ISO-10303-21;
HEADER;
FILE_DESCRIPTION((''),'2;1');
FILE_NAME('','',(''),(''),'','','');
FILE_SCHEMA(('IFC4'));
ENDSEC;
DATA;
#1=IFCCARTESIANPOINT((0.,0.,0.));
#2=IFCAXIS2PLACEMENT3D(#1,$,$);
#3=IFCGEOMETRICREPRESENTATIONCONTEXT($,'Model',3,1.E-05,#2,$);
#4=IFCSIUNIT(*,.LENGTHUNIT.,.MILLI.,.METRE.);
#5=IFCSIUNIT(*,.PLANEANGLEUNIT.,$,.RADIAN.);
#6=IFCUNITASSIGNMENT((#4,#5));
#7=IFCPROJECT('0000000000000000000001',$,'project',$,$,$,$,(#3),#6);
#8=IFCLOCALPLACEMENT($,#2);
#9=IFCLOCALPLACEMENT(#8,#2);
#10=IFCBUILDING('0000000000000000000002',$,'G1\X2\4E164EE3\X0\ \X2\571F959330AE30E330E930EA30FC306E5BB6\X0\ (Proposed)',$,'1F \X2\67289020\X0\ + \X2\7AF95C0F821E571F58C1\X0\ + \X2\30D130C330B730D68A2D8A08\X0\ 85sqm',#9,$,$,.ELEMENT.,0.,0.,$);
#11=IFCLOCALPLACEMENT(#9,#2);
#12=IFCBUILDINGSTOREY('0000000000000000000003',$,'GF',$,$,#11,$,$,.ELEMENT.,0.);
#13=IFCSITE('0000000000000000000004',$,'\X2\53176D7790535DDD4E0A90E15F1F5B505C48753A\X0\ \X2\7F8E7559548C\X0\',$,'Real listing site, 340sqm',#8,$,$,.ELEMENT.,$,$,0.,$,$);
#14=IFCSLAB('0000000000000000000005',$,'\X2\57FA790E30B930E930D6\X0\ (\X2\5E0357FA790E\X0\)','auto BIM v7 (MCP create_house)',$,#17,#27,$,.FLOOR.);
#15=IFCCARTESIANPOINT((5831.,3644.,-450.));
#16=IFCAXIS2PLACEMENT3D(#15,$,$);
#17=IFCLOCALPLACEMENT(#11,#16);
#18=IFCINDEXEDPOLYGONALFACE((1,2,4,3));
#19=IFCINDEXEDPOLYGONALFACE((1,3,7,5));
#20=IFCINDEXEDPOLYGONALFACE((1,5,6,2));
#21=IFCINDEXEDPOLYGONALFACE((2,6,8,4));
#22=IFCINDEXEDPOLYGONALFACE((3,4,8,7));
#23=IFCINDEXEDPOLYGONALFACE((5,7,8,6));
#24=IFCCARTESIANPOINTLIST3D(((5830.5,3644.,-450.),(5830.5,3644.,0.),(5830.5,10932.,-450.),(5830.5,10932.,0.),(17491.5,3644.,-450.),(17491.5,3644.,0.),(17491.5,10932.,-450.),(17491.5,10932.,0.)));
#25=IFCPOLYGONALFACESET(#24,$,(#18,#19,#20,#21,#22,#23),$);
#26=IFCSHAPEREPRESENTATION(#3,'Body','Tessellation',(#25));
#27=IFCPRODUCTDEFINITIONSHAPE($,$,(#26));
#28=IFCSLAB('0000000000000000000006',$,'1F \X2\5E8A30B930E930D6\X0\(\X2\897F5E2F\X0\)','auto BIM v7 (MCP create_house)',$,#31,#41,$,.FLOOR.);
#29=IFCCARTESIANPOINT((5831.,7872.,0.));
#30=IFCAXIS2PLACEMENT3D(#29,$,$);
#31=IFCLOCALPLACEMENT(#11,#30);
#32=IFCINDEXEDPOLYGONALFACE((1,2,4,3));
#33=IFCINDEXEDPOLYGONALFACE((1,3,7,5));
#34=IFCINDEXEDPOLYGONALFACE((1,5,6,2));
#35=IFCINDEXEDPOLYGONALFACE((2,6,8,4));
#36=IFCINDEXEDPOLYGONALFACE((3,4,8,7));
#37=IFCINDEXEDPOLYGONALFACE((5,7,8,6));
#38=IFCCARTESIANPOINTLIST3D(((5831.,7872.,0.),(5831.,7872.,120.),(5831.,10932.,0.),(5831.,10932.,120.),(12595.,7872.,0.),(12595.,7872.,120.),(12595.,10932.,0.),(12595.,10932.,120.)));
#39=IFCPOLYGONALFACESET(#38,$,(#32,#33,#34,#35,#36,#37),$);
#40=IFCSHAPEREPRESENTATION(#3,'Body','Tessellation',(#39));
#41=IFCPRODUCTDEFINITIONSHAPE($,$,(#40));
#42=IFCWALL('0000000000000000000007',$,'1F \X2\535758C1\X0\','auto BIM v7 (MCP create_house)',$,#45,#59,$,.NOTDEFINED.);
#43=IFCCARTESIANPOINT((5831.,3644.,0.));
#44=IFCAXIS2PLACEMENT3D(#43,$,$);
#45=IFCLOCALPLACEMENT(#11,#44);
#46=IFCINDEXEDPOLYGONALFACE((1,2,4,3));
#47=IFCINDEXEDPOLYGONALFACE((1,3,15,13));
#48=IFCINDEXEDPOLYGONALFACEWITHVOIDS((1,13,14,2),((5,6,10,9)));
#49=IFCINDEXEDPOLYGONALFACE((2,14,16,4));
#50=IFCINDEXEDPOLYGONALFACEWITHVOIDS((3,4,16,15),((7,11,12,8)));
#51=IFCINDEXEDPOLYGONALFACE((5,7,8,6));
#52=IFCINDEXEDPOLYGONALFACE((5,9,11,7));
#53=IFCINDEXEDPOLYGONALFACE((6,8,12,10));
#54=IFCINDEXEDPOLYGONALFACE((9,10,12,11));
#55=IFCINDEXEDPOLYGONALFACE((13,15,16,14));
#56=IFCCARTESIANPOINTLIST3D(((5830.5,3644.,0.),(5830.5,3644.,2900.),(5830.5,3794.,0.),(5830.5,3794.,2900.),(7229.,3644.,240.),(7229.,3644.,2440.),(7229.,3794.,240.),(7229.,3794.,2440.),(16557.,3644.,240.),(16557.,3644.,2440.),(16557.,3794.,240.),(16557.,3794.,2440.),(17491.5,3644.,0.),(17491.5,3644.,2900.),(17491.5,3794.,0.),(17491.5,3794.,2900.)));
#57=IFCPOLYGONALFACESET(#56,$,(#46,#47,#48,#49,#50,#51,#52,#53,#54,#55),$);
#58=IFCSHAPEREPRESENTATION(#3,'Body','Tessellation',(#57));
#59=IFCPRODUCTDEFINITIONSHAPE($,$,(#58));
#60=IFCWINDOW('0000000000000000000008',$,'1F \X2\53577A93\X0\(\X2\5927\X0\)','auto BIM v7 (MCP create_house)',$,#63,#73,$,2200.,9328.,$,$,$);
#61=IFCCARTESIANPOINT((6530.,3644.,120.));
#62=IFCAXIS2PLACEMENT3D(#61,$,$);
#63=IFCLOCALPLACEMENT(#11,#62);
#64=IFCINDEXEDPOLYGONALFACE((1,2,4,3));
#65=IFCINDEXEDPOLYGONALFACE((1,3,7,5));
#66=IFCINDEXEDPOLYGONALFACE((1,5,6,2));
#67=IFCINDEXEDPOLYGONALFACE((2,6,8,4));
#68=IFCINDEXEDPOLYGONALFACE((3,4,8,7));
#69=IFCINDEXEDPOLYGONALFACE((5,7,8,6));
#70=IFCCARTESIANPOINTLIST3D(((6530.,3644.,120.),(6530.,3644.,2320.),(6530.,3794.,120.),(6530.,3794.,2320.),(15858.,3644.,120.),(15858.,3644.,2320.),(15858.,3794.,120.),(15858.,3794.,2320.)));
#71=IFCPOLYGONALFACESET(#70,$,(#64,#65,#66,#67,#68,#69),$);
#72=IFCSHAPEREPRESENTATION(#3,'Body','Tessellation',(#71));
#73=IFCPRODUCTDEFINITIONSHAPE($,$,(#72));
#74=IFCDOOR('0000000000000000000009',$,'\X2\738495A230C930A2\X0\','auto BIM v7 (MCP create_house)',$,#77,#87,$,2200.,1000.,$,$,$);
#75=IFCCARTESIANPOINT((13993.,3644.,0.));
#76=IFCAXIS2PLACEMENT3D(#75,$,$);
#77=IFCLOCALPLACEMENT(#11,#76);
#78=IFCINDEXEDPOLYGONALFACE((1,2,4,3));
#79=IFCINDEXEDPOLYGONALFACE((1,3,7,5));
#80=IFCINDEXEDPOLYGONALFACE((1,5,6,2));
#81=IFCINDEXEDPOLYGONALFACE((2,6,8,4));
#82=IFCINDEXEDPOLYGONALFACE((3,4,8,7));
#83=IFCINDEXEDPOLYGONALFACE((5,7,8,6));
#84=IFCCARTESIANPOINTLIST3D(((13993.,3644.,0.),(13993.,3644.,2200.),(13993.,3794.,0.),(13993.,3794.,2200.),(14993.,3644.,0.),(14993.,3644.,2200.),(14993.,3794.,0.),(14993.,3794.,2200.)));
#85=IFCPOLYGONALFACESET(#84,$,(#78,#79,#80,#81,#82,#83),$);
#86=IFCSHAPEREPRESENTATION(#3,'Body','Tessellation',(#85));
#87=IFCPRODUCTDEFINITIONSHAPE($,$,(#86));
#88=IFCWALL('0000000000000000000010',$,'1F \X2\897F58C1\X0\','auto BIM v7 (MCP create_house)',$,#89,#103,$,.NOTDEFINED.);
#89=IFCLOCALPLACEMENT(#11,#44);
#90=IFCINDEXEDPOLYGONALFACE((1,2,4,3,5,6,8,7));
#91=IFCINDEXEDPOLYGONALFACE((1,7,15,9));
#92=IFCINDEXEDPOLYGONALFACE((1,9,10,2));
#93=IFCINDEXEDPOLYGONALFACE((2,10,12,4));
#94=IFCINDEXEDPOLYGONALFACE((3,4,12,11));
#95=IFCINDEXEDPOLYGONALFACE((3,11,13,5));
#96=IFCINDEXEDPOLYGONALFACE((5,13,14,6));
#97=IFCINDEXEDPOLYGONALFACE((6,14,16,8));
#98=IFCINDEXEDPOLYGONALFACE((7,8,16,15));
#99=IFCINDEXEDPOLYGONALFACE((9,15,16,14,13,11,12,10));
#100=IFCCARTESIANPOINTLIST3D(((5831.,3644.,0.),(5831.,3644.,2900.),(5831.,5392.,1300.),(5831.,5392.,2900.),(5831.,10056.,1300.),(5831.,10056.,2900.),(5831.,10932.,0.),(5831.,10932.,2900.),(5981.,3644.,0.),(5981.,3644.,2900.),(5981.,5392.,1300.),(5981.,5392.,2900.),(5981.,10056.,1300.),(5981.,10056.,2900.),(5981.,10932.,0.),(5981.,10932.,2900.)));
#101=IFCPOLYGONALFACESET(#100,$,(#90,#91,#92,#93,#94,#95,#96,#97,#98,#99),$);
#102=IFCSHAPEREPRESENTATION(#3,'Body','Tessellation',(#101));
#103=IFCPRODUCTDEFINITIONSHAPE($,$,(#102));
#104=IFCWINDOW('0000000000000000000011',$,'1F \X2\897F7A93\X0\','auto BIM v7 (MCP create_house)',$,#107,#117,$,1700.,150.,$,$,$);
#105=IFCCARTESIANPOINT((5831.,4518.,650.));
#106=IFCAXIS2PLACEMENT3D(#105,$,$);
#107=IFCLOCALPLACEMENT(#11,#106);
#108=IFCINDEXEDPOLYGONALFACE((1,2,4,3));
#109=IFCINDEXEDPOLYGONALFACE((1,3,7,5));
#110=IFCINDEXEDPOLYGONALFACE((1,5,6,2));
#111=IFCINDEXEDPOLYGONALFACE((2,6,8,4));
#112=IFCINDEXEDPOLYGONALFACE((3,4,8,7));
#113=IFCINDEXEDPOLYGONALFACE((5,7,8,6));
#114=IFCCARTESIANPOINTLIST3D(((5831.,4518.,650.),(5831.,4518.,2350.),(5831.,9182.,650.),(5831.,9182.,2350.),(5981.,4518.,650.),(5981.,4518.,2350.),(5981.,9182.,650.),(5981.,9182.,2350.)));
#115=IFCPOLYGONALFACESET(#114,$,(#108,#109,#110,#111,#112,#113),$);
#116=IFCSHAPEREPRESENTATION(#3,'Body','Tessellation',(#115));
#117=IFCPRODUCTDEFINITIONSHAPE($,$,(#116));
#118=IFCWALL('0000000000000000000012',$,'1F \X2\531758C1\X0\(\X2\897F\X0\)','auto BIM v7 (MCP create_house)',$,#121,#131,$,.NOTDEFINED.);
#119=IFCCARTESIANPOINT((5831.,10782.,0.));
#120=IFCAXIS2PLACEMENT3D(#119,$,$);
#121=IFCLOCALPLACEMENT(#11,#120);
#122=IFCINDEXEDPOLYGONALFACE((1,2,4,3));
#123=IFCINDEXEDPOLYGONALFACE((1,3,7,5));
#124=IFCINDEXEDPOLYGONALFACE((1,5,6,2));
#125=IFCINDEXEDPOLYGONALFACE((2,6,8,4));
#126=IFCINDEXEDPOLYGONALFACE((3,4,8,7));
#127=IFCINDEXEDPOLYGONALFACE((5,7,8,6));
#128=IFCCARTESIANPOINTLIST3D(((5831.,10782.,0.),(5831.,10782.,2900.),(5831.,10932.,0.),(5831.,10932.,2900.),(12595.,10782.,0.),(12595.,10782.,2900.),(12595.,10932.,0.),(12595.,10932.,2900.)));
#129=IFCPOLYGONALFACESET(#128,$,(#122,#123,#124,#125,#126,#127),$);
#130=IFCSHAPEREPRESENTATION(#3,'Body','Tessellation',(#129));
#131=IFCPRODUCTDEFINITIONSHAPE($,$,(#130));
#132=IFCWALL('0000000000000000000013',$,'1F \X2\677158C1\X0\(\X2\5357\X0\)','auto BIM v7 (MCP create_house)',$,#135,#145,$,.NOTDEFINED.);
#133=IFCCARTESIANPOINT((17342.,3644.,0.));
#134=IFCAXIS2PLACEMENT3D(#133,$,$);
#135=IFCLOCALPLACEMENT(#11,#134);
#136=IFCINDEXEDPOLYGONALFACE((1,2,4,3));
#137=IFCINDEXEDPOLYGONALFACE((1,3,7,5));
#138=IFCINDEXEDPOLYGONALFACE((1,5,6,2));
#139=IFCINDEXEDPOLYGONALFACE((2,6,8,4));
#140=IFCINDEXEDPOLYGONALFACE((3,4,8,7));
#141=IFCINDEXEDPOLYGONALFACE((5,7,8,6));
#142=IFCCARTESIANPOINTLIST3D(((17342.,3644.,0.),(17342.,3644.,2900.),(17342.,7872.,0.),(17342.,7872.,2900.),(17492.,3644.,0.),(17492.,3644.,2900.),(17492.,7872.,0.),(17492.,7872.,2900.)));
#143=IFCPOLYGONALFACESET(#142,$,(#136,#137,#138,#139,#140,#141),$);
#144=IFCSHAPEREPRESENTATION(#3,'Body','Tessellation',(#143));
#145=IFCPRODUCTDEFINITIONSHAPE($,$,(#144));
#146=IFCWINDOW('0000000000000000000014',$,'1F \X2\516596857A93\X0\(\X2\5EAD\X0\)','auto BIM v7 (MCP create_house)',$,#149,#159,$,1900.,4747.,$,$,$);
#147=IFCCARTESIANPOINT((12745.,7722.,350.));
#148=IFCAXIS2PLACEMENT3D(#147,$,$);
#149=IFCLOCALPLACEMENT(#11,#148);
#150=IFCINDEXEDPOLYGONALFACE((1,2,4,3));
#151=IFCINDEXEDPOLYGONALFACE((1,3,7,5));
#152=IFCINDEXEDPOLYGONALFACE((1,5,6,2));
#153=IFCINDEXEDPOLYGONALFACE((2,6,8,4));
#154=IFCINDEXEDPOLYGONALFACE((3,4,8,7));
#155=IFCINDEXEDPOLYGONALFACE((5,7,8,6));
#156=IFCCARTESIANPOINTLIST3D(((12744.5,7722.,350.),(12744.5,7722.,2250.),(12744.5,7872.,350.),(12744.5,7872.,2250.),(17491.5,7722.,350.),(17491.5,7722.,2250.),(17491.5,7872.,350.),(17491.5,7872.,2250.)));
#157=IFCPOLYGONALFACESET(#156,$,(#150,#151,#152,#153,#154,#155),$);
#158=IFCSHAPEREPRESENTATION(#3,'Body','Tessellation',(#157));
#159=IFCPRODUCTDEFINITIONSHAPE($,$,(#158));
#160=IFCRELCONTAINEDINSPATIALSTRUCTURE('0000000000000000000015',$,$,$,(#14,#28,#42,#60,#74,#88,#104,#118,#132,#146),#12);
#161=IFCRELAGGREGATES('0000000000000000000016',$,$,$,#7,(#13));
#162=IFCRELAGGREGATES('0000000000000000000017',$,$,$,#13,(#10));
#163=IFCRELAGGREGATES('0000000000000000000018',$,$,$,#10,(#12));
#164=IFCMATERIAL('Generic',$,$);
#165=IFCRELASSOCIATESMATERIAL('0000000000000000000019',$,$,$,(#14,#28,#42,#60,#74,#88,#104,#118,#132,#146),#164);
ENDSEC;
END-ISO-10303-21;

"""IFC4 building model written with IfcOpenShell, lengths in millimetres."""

from ifc_helpers import new_model, si_unit, frame, frame_2d, origin, place, context, project, spatial, rectangle, extrude, material, element, fill, save


model = new_model("IFC4")

# Units and contexts
model_context = context("Model", 3, precision=1e-05, world=origin())
ifc_project = project(units=[si_unit("LENGTHUNIT", "METRE", prefix="MILLI"), si_unit("PLANEANGLEUNIT", "RADIAN")], contexts=[model_context])

# Site, building, storey
site_placement = place(None, origin())
site = spatial("IfcSite", under=ifc_project, at=site_placement, Name="北海道川上郡弟子屈町 美留和", ObjectType="Real listing site, 340sqm", CompositionType="ELEMENT", RefElevation=0.0)
building_placement = place(site_placement, origin())
building = spatial("IfcBuilding", under=site, at=building_placement, Name="G1世代 土間ギャラリーの家 (Proposed)", ObjectType="1F 木造 + 竹小舞土壁 + パッシブ設計 85sqm", CompositionType="ELEMENT", ElevationOfRefHeight=0.0, ElevationOfTerrain=0.0)
storey_placement = place(building_placement, origin())
storey = spatial("IfcBuildingStorey", under=building, at=storey_placement, Name="GF", CompositionType="ELEMENT", Elevation=0.0)

# Slabs
ifc_material = material(Name="Generic")
slab_1_placement = place(storey_placement, frame((5831.0, 3644.0, -450.0)))
element("IfcSlab", 1, at=slab_1_placement, inside=storey, material=ifc_material, Name="基礎スラブ (布基礎)", Description="auto BIM v7 (MCP create_house)", PredefinedType="FLOOR", context=model_context, shape_type="SweptSolid", body=[
    extrude(rectangle(XDim=11661.0, YDim=7288.0, at=frame_2d((5830.0, 3644.0))), frame((5831.0, 3644.0, -450.0)), (0.0, 0.0, 1.0), 450.0),
])
slab_2_placement = place(storey_placement, frame((5831.0, 7872.0, 0.0)))
element("IfcSlab", 2, at=slab_2_placement, inside=storey, material=ifc_material, Name="1F 床スラブ(西帯)", Description="auto BIM v7 (MCP create_house)", PredefinedType="FLOOR", context=model_context, shape_type="SweptSolid", body=[
    extrude(rectangle(XDim=6764.0, YDim=3060.0, at=frame_2d((3382.0, 1530.0))), frame((5831.0, 7872.0, 0.0)), (0.0, 0.0, 1.0), 120.0),
])

# Wall, openings, window, door
wall_1_placement = place(storey_placement, frame((5831.0, 3644.0, 0.0)))
wall_1 = element("IfcWall", 3, at=wall_1_placement, inside=storey, material=ifc_material, Name="1F 南壁", Description="auto BIM v7 (MCP create_house)", PredefinedType="NOTDEFINED", context=model_context, shape_type="SweptSolid", body=[
    extrude(rectangle(XDim=11661.0, YDim=150.0, at=frame_2d((5830.0, 75.0))), frame((5831.0, 3644.0, 0.0)), (0.0, 0.0, 1.0), 2900.0),
])
opening_1_placement = place(storey_placement, frame((6530.0, 3644.0, 120.0)))
opening_1 = element("IfcOpeningElement", 4, at=opening_1_placement, cuts=wall_1, PredefinedType="NOTDEFINED", context=model_context, shape_type="SweptSolid", body=[
    extrude(rectangle(XDim=9328.0, YDim=150.0, at=frame_2d((4664.0, 75.0))), frame((6530.0, 3644.0, 120.0)), (0.0, 0.0, 1.0), 2200.0),
])
opening_2_placement = place(storey_placement, frame((13993.0, 3644.0, 0.0)))
opening_2 = element("IfcOpeningElement", 5, at=opening_2_placement, cuts=wall_1, PredefinedType="NOTDEFINED", context=model_context, shape_type="SweptSolid", body=[
    extrude(rectangle(XDim=1000.0, YDim=150.0, at=frame_2d((500.0, 75.0))), frame((13993.0, 3644.0, 0.0)), (0.0, 0.0, 1.0), 2200.0),
])
window_1_placement = place(storey_placement, frame((6530.0, 3644.0, 120.0)))
window_1 = element("IfcWindow", 6, at=window_1_placement, inside=storey, material=ifc_material, Name="1F 南窓(大)", Description="auto BIM v7 (MCP create_house)", OverallHeight=2200.0, OverallWidth=9328.0, context=model_context, shape_type="SweptSolid", body=[
    extrude(rectangle(XDim=9328.0, YDim=150.0, at=frame_2d((4664.0, 75.0))), frame((6530.0, 3644.0, 120.0)), (0.0, 0.0, 1.0), 2200.0),
])
fill(opening_1, window_1)
door_placement = place(storey_placement, frame((13993.0, 3644.0, 0.0)))
door = element("IfcDoor", 7, at=door_placement, inside=storey, material=ifc_material, Name="玄関ドア", Description="auto BIM v7 (MCP create_house)", OverallHeight=2200.0, OverallWidth=1000.0, context=model_context, shape_type="SweptSolid", body=[
    extrude(rectangle(XDim=1000.0, YDim=150.0, at=frame_2d((500.0, 75.0))), frame((13993.0, 3644.0, 0.0)), (0.0, 0.0, 1.0), 2200.0),
])
fill(opening_2, door)

# Wall, opening, window
wall_2_placement = place(storey_placement, frame((5831.0, 3644.0, 0.0)))
wall_2 = element("IfcWall", 8, at=wall_2_placement, inside=storey, material=ifc_material, Name="1F 西壁", Description="auto BIM v7 (MCP create_house)", PredefinedType="NOTDEFINED", context=model_context, shape_type="SweptSolid", body=[
    extrude(rectangle(XDim=150.0, YDim=7288.0, at=frame_2d((75.0, 3644.0))), frame((5831.0, 3644.0, 0.0)), (0.0, 0.0, 1.0), 2900.0),
])
opening_3_placement = place(storey_placement, frame((5831.0, 4518.0, 650.0)))
opening_3 = element("IfcOpeningElement", 9, at=opening_3_placement, cuts=wall_2, PredefinedType="NOTDEFINED", context=model_context, shape_type="SweptSolid", body=[
    extrude(rectangle(XDim=150.0, YDim=4664.0, at=frame_2d((75.0, 2332.0))), frame((5831.0, 4518.0, 650.0)), (0.0, 0.0, 1.0), 1700.0),
])
window_2_placement = place(storey_placement, frame((5831.0, 4518.0, 650.0)))
window_2 = element("IfcWindow", 10, at=window_2_placement, inside=storey, material=ifc_material, Name="1F 西窓", Description="auto BIM v7 (MCP create_house)", OverallHeight=1700.0, OverallWidth=150.0, context=model_context, shape_type="SweptSolid", body=[
    extrude(rectangle(XDim=150.0, YDim=4664.0, at=frame_2d((75.0, 2332.0))), frame((5831.0, 4518.0, 650.0)), (0.0, 0.0, 1.0), 1700.0),
])
fill(opening_3, window_2)

# Wall
wall_3_placement = place(storey_placement, frame((5831.0, 10782.0, 0.0)))
element("IfcWall", 11, at=wall_3_placement, inside=storey, material=ifc_material, Name="1F 北壁(西)", Description="auto BIM v7 (MCP create_house)", PredefinedType="NOTDEFINED", context=model_context, shape_type="SweptSolid", body=[
    extrude(rectangle(XDim=6764.0, YDim=150.0, at=frame_2d((3382.0, 75.0))), frame((5831.0, 10782.0, 0.0)), (0.0, 0.0, 1.0), 2900.0),
])

# Wall, opening, window
wall_4_placement = place(storey_placement, frame((17342.0, 3644.0, 0.0)))
wall_4 = element("IfcWall", 12, at=wall_4_placement, inside=storey, material=ifc_material, Name="1F 東壁(南)", Description="auto BIM v7 (MCP create_house)", PredefinedType="NOTDEFINED", context=model_context, shape_type="SweptSolid", body=[
    extrude(rectangle(XDim=150.0, YDim=4228.0, at=frame_2d((75.0, 2114.0))), frame((17342.0, 3644.0, 0.0)), (0.0, 0.0, 1.0), 2900.0),
])
opening_4_placement = place(storey_placement, frame((12745.0, 7722.0, 350.0)))
opening_4 = element("IfcOpeningElement", 13, at=opening_4_placement, cuts=wall_4, PredefinedType="NOTDEFINED", context=model_context, shape_type="SweptSolid", body=[
    extrude(rectangle(XDim=4747.0, YDim=150.0, at=frame_2d((2373.0, 75.0))), frame((12745.0, 7722.0, 350.0)), (0.0, 0.0, 1.0), 1900.0),
])
window_3_placement = place(storey_placement, frame((12745.0, 7722.0, 350.0)))
window_3 = element("IfcWindow", 14, at=window_3_placement, inside=storey, material=ifc_material, Name="1F 入隅窓(庭)", Description="auto BIM v7 (MCP create_house)", OverallHeight=1900.0, OverallWidth=4747.0, context=model_context, shape_type="SweptSolid", body=[
    extrude(rectangle(XDim=4747.0, YDim=150.0, at=frame_2d((2373.0, 75.0))), frame((12745.0, 7722.0, 350.0)), (0.0, 0.0, 1.0), 1900.0),
])
fill(opening_4, window_3)

save(model, "model.ifc")
